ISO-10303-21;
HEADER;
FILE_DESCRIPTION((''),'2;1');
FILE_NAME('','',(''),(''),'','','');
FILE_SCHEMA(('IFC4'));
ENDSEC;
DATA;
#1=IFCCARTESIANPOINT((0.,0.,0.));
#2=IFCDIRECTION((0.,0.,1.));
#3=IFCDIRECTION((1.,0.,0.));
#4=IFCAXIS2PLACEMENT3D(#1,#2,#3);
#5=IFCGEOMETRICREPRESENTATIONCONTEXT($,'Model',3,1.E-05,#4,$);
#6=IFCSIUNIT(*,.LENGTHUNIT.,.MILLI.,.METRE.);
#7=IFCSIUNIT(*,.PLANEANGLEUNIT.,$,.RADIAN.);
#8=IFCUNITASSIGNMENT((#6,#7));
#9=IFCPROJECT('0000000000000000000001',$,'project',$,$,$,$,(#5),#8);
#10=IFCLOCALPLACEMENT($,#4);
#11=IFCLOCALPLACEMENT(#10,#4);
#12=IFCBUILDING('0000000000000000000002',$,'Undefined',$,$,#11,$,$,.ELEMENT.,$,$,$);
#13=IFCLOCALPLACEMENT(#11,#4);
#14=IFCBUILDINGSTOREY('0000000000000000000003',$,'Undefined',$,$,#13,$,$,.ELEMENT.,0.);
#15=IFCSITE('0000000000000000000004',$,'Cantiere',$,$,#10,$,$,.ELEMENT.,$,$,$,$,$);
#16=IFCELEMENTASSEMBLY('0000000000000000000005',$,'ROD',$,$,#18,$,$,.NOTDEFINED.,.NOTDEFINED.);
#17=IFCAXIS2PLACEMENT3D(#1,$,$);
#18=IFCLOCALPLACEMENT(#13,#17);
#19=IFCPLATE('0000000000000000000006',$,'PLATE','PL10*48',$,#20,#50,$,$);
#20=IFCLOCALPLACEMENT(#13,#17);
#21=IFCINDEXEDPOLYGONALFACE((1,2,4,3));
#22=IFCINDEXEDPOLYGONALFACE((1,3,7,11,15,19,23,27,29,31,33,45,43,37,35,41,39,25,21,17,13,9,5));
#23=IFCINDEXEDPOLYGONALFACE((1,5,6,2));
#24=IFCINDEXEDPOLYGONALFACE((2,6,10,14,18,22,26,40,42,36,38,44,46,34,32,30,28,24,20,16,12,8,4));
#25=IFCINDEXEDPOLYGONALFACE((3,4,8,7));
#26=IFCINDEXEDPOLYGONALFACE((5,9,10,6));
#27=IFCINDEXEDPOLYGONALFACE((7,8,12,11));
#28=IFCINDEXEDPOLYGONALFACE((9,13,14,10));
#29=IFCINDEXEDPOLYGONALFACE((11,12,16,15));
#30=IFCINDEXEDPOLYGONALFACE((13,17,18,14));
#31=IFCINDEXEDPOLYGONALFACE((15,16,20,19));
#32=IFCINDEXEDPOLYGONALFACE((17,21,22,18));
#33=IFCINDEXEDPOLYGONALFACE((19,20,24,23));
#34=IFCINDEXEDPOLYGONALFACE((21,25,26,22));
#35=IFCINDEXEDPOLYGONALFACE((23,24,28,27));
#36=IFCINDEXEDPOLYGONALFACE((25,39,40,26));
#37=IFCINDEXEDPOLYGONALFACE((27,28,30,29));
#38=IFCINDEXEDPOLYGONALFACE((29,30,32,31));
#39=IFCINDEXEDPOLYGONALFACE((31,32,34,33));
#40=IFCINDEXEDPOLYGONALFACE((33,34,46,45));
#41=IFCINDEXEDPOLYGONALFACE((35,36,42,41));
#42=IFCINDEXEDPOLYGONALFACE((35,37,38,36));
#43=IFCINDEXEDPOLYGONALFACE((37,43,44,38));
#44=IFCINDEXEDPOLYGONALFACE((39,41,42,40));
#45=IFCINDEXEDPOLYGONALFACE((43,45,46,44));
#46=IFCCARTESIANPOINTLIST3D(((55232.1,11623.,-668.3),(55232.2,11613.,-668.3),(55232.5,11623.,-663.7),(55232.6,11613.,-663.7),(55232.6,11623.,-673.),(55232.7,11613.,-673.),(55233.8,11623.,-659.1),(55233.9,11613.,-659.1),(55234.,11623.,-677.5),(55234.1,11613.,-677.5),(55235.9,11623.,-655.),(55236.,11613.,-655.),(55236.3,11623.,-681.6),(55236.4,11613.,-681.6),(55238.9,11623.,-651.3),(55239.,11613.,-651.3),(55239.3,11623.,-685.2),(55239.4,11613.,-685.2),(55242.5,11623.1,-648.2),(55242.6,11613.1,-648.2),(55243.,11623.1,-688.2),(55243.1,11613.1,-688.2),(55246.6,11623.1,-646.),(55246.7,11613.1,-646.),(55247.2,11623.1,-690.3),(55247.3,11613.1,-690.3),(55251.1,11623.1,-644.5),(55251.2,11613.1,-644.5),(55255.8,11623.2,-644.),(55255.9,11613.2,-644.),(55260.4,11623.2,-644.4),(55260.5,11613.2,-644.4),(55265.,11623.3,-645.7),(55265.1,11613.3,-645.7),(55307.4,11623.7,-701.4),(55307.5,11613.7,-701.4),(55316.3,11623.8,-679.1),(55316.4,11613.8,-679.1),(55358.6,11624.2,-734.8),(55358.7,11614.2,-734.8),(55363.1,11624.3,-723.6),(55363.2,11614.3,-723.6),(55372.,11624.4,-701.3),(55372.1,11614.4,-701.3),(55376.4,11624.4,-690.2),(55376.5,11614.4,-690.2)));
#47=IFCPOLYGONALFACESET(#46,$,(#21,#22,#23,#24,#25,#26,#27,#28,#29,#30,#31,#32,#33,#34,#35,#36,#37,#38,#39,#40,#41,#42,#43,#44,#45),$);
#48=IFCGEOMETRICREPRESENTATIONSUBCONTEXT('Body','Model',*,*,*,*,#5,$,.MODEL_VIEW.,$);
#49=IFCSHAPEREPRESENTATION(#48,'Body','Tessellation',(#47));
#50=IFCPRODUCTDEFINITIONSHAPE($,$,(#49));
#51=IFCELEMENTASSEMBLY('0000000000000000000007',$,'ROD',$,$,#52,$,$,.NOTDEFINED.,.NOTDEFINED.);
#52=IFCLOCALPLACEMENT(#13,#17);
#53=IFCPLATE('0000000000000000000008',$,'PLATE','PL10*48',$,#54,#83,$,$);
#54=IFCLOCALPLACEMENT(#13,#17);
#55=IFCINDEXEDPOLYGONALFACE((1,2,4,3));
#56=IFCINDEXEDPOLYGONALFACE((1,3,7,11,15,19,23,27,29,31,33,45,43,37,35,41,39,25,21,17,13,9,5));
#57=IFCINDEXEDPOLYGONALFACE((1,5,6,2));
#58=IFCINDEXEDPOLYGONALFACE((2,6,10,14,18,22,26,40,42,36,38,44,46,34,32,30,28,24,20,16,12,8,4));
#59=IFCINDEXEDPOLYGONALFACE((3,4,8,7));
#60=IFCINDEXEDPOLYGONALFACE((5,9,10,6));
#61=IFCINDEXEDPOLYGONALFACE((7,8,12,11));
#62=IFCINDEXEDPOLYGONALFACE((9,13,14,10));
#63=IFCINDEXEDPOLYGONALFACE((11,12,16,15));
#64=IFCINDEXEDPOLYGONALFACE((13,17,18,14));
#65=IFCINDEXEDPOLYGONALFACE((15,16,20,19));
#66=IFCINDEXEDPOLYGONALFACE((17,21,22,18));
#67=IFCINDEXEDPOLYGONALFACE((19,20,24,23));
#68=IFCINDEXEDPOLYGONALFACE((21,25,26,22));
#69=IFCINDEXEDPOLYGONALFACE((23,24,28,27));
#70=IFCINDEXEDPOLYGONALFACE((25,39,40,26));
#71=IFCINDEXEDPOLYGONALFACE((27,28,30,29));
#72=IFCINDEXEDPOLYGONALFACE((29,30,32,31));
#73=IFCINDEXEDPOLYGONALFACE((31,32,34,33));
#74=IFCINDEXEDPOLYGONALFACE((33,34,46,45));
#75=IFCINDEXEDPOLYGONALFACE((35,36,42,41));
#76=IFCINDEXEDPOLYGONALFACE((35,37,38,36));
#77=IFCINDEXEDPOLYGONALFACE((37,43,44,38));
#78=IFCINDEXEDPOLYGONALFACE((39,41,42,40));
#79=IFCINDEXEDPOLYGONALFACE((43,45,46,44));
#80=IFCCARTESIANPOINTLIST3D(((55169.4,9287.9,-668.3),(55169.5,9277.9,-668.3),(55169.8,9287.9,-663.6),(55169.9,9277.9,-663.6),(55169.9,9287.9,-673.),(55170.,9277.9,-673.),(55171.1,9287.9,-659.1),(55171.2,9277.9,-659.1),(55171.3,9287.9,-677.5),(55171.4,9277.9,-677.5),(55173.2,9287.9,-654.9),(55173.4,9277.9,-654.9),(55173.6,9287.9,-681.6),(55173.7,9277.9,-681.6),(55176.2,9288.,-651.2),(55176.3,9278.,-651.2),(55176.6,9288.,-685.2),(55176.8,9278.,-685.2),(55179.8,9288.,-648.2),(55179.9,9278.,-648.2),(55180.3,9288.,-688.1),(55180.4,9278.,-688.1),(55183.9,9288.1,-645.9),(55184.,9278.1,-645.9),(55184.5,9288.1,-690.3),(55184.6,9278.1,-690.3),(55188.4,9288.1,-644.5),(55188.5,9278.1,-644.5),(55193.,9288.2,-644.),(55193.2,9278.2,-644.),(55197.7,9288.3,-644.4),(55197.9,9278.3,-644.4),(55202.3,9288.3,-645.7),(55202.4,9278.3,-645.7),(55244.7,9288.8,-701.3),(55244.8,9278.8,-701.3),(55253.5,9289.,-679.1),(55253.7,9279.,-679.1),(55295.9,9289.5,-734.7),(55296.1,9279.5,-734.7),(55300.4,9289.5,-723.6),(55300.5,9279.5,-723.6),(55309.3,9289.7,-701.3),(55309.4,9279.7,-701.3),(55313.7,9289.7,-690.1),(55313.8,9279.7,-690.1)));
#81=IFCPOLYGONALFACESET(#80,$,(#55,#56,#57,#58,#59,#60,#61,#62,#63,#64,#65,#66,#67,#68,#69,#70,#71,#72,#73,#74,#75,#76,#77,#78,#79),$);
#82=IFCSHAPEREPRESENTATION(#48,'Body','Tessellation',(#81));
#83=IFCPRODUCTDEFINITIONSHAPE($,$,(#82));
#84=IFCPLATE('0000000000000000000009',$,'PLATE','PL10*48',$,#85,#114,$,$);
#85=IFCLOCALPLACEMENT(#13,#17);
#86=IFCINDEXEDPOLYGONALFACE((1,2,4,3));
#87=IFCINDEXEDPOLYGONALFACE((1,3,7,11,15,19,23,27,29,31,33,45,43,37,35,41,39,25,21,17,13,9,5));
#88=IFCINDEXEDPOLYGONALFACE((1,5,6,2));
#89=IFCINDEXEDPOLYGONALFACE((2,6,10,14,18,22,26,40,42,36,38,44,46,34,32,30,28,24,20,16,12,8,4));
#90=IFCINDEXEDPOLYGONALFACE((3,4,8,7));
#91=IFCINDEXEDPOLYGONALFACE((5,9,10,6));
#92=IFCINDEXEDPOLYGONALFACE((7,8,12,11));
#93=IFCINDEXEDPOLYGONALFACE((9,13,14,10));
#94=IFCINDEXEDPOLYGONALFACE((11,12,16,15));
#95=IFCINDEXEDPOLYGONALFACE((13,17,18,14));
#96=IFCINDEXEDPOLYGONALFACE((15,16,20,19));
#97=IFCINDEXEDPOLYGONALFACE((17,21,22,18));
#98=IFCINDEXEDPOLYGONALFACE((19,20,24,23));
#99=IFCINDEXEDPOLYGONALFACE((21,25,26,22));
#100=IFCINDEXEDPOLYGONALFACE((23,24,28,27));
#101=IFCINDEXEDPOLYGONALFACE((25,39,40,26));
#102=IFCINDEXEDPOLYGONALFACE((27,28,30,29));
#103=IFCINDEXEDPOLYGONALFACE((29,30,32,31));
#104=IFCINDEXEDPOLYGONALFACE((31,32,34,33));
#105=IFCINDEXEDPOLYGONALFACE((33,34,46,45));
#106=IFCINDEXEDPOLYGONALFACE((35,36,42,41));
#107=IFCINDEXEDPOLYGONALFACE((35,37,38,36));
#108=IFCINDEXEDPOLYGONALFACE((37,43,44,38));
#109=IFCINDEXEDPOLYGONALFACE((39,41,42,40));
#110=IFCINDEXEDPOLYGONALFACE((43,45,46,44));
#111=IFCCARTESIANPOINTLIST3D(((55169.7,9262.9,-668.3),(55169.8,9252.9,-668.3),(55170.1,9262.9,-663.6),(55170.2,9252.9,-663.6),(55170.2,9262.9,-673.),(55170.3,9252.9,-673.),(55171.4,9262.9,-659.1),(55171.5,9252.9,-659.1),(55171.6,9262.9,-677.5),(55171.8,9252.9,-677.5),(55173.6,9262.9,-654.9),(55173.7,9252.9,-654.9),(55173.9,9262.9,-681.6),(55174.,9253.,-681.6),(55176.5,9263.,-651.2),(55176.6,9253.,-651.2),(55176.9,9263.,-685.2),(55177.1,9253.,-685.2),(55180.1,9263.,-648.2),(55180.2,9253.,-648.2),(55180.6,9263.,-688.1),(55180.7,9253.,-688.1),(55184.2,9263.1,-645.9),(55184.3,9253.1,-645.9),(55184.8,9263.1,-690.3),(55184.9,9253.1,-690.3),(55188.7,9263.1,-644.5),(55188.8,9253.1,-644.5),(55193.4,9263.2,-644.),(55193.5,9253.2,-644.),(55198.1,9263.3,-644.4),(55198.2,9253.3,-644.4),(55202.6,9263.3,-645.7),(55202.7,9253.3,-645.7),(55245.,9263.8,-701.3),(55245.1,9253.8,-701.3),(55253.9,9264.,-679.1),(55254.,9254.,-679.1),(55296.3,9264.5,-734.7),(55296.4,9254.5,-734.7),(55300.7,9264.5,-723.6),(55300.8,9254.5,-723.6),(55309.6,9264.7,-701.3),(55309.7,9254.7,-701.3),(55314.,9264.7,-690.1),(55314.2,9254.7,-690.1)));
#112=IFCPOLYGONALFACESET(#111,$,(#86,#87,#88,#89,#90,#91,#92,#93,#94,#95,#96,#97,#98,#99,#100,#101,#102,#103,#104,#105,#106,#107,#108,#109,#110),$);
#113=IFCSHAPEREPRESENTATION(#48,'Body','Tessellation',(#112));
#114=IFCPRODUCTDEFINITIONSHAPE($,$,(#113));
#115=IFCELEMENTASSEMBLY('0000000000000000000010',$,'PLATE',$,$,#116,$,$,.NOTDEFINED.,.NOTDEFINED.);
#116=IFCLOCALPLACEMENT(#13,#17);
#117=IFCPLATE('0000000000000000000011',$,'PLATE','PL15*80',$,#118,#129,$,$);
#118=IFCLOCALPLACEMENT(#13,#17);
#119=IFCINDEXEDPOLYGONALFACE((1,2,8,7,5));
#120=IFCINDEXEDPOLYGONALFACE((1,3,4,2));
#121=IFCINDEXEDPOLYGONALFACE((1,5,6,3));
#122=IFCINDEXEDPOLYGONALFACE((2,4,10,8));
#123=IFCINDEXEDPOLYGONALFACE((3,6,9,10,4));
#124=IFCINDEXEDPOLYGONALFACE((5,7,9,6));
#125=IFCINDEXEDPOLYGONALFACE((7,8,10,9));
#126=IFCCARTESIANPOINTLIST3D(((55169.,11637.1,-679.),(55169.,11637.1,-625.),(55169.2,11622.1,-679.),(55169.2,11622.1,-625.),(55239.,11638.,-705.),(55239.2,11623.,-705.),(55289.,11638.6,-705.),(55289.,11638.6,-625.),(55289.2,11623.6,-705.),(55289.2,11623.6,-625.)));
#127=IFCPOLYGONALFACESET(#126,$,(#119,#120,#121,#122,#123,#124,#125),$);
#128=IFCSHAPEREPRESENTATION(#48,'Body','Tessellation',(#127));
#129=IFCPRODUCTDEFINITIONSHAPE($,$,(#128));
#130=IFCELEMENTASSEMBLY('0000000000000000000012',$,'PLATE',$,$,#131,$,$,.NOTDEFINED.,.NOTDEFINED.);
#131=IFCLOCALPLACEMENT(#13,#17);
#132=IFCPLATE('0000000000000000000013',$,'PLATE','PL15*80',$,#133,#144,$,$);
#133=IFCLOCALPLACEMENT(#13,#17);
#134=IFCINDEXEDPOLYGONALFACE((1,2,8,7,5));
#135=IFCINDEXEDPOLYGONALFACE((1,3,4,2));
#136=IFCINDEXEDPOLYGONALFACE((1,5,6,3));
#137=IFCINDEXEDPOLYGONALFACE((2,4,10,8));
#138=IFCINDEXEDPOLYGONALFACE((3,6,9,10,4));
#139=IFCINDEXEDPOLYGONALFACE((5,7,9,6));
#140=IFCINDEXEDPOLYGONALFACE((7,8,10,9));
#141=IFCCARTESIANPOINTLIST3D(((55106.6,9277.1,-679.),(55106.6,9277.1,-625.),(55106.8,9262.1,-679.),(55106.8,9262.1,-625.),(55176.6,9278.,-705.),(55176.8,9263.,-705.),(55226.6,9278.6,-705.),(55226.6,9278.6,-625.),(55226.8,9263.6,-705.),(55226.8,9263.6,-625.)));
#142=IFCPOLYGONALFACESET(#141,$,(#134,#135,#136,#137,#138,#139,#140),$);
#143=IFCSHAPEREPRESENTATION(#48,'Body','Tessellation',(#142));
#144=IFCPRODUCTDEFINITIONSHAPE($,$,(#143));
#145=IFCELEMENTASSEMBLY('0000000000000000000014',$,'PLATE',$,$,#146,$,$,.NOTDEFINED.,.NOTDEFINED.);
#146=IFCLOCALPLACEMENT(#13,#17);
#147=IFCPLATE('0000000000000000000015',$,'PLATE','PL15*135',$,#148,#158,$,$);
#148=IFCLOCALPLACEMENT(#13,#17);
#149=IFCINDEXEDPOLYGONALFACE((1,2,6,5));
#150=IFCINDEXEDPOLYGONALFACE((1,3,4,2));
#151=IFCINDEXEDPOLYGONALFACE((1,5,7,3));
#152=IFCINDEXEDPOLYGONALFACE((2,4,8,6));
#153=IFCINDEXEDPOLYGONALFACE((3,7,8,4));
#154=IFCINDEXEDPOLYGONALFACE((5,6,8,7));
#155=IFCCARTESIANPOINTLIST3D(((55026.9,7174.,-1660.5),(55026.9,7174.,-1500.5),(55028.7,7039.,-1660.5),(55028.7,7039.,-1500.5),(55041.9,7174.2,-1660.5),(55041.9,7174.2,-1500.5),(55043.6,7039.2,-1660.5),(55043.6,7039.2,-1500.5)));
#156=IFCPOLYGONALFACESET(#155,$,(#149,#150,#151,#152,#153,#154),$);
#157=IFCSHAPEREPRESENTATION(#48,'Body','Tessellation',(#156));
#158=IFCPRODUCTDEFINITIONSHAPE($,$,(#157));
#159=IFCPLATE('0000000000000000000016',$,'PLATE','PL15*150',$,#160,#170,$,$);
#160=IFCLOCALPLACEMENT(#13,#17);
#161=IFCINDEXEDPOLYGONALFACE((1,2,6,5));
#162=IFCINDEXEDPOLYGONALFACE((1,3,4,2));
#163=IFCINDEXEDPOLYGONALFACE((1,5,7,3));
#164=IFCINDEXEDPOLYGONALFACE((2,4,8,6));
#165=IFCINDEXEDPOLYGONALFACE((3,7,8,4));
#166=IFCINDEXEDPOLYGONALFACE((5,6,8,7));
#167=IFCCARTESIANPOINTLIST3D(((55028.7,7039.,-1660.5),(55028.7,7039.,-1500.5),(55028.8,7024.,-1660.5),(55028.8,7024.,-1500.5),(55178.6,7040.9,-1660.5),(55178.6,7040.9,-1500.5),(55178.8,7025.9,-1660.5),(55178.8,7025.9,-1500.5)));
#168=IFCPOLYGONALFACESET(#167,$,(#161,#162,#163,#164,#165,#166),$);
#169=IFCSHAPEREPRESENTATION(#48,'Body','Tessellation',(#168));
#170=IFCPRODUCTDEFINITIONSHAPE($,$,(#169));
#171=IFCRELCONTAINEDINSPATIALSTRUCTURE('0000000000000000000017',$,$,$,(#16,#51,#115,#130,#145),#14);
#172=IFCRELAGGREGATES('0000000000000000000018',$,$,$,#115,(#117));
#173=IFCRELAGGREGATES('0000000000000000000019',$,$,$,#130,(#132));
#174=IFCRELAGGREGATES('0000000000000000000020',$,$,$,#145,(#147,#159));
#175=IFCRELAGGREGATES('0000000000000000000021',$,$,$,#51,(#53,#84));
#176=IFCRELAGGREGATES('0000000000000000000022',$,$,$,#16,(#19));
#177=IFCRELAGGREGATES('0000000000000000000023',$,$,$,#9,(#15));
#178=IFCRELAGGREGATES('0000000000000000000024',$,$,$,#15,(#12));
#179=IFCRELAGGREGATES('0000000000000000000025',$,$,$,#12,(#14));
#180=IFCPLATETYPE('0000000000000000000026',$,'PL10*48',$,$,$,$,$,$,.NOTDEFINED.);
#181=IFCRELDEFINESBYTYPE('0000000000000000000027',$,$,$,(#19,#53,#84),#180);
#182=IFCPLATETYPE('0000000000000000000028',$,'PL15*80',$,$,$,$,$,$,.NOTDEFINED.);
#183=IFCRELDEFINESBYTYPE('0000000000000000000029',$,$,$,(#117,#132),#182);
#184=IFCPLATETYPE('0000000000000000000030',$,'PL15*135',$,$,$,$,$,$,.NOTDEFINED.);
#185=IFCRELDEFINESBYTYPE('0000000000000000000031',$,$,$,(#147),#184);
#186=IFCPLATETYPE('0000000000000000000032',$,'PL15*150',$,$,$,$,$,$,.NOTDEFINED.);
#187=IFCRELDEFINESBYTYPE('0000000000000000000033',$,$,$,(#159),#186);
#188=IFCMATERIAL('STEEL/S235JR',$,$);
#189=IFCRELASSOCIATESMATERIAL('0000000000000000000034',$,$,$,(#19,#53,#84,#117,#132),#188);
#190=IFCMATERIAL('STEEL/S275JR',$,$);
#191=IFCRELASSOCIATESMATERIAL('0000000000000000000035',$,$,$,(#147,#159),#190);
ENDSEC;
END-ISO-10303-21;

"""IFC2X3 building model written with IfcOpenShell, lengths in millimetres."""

from ifc_helpers import new_model, si_unit, frame, origin_with_axes, place, context, subcontext, project, spatial, polyline, outline, extrude, material, type_object, element, aggregate, save


model = new_model("IFC2X3")

# Units and contexts
model_context = context("Model", 3, precision=1e-05, world=origin_with_axes())
body_context = subcontext(model_context, "Body", "Model", "MODEL_VIEW")
ifc_project = project(units=[si_unit("LENGTHUNIT", "METRE", prefix="MILLI"), si_unit("PLANEANGLEUNIT", "RADIAN")], contexts=[model_context])

# Site, building, storey
site_placement = place(None, origin_with_axes())
site = spatial("IfcSite", under=ifc_project, at=site_placement, Name="Cantiere", CompositionType="ELEMENT")
building_placement = place(site_placement, origin_with_axes())
building = spatial("IfcBuilding", under=site, at=building_placement, Name="Undefined", CompositionType="ELEMENT")
storey_placement = place(building_placement, origin_with_axes())
storey = spatial("IfcBuildingStorey", under=building, at=storey_placement, Name="Undefined", CompositionType="ELEMENT", Elevation=0.0)

# Shared definitions
ifc_material_1 = material(Name="STEEL/S275JR")
ifc_material_2 = material(Name="STEEL/S235JR")

# Element assemblies, plates
plate_type_1 = type_object("IfcPlateType", Name="PL10*48", PredefinedType="NOTDEFINED")
assembly_1_placement = place(storey_placement, origin_with_axes())
assembly_1 = element("IfcElementAssembly", 1, at=assembly_1_placement, inside=storey, Name="ROD", AssemblyPlace="NOTDEFINED", PredefinedType="NOTDEFINED")
plate_1_placement = place(assembly_1_placement, frame((55376.5, 11619.4, -690.2), z_axis=(0.009999, -0.99995, 0.0), x_axis=(-0.928849, -0.009288, 0.370341)))
plate_1 = element("IfcPlate", 2, at=plate_1_placement, type_object=plate_type_1, material=ifc_material_2, Name="PLATE", Description="PL10*48", context=body_context, shape_type="SweptSolid", body=[
    extrude(outline(polyline([(0.0, 0.0), (120.0, 0.0), (124.7, 0.5), (129.2, 1.8), (133.3, 4.0), (137.0, 7.0), (140.0, 10.7), (142.2, 14.8), (143.5, 19.3), (144.0, 24.0), (144.0, 24.0), (143.5, 28.7), (142.2, 33.2), (140.0, 37.3), (137.0, 41.0), (133.3, 44.0), (129.2, 46.2), (124.7, 47.5), (120.0, 48.0), (0.0, 48.0), (0.0, 36.0), (60.0, 36.0), (60.0, 12.0), (0.0, 12.0), (0.0, 0.0)])), frame((0.0, 0.0, -5.0), z_axis=(0.0, 0.0, 1.0), x_axis=(1.0, 0.0, 0.0)), (0.0, 0.0, 1.0), 10.0),
])
assembly_2_placement = place(storey_placement, origin_with_axes())
assembly_2 = element("IfcElementAssembly", 3, at=assembly_2_placement, inside=storey, Name="ROD", AssemblyPlace="NOTDEFINED", PredefinedType="NOTDEFINED")
plate_2_placement = place(assembly_2_placement, frame((55313.8, 9284.7, -690.1), z_axis=(0.012617, -0.99992, 0.0), x_axis=(-0.928822, -0.01172, 0.370341)))
plate_2 = element("IfcPlate", 4, at=plate_2_placement, type_object=plate_type_1, material=ifc_material_2, Name="PLATE", Description="PL10*48", context=body_context, shape_type="SweptSolid", body=[
    extrude(outline(polyline([(0.0, 0.0), (120.0, 0.0), (124.7, 0.5), (129.2, 1.8), (133.3, 4.0), (137.0, 7.0), (140.0, 10.7), (142.2, 14.8), (143.5, 19.3), (144.0, 24.0), (144.0, 24.0), (143.5, 28.7), (142.2, 33.2), (140.0, 37.3), (137.0, 41.0), (133.3, 44.0), (129.2, 46.2), (124.7, 47.5), (120.0, 48.0), (0.0, 48.0), (0.0, 36.0), (60.0, 36.0), (60.0, 12.0), (0.0, 12.0), (0.0, 0.0)])), frame((0.0, 0.0, -5.0), z_axis=(0.0, 0.0, 1.0), x_axis=(1.0, 0.0, 0.0)), (0.0, 0.0, 1.0), 10.0),
])
plate_3_placement = place(assembly_2_placement, frame((55314.1, 9259.7, -690.1), z_axis=(0.012617, -0.99992, 0.0), x_axis=(-0.928822, -0.01172, 0.370341)))
plate_3 = element("IfcPlate", 5, at=plate_3_placement, type_object=plate_type_1, material=ifc_material_2, Name="PLATE", Description="PL10*48", context=body_context, shape_type="SweptSolid", body=[
    extrude(outline(polyline([(0.0, 0.0), (120.0, 0.0), (124.7, 0.5), (129.2, 1.8), (133.3, 4.0), (137.0, 7.0), (140.0, 10.7), (142.2, 14.8), (143.5, 19.3), (144.0, 24.0), (144.0, 24.0), (143.5, 28.7), (142.2, 33.2), (140.0, 37.3), (137.0, 41.0), (133.3, 44.0), (129.2, 46.2), (124.7, 47.5), (120.0, 48.0), (0.0, 48.0), (0.0, 36.0), (60.0, 36.0), (60.0, 12.0), (0.0, 12.0), (0.0, 0.0)])), frame((0.0, 0.0, -5.0), z_axis=(0.0, 0.0, 1.0), x_axis=(1.0, 0.0, 0.0)), (0.0, 0.0, 1.0), 10.0),
])

# Element assemblies, plates
assembly_3_placement = place(storey_placement, origin_with_axes())
assembly_3 = element("IfcElementAssembly", 6, at=assembly_3_placement, inside=storey, Name="PLATE", AssemblyPlace="NOTDEFINED", PredefinedType="NOTDEFINED")
plate_type_2 = type_object("IfcPlateType", Name="PL15*80", PredefinedType="NOTDEFINED")
plate_4_placement = place(assembly_3_placement, frame((55289.1, 11631.1, -625.0), z_axis=(0.012617, -0.99992, 0.0), x_axis=(-0.99992, -0.012617, 0.0)))
plate_4 = element("IfcPlate", 7, at=plate_4_placement, type_object=plate_type_2, material=ifc_material_2, Name="PLATE", Description="PL15*80", context=body_context, shape_type="SweptSolid", body=[
    extrude(outline(polyline([(0.0, 0.0), (120.0, 0.0), (120.0, 54.0), (50.0, 80.0), (0.0, 80.0), (0.0, 0.0)])), frame((0.0, 0.0, -7.5), z_axis=(0.0, 0.0, 1.0), x_axis=(1.0, 0.0, 0.0)), (0.0, 0.0, 1.0), 15.0),
])
aggregate(assembly_3, [plate_4])
assembly_4_placement = place(storey_placement, origin_with_axes())
assembly_4 = element("IfcElementAssembly", 8, at=assembly_4_placement, inside=storey, Name="PLATE", AssemblyPlace="NOTDEFINED", PredefinedType="NOTDEFINED")
plate_5_placement = place(assembly_4_placement, frame((55226.7, 9271.1, -625.0), z_axis=(0.012617, -0.99992, 0.0), x_axis=(-0.99992, -0.012617, 0.0)))
plate_5 = element("IfcPlate", 9, at=plate_5_placement, type_object=plate_type_2, material=ifc_material_2, Name="PLATE", Description="PL15*80", context=body_context, shape_type="SweptSolid", body=[
    extrude(outline(polyline([(0.0, 0.0), (120.0, 0.0), (120.0, 54.0), (50.0, 80.0), (0.0, 80.0), (0.0, 0.0)])), frame((0.0, 0.0, -7.5), z_axis=(0.0, 0.0, 1.0), x_axis=(1.0, 0.0, 0.0)), (0.0, 0.0, 1.0), 15.0),
])
aggregate(assembly_4, [plate_5])

# Element assembly, plates
assembly_5_placement = place(storey_placement, origin_with_axes())
assembly_5 = element("IfcElementAssembly", 10, at=assembly_5_placement, inside=storey, Name="PLATE", AssemblyPlace="NOTDEFINED", PredefinedType="NOTDEFINED")
plate_type_3 = type_object("IfcPlateType", Name="PL15*135", PredefinedType="NOTDEFINED")
plate_6_placement = place(assembly_5_placement, frame((55034.4, 7174.1, -1500.5), z_axis=(-0.99992, -0.012617, 0.0), x_axis=(0.0, 0.000001, -1.0)))
plate_6 = element("IfcPlate", 11, at=plate_6_placement, type_object=plate_type_3, material=ifc_material_1, Name="PLATE", Description="PL15*135", context=body_context, shape_type="SweptSolid", body=[
    extrude(outline(polyline([(0.0, 0.0), (160.0, 0.0), (160.0, 135.0), (0.0, 135.0), (0.0, 0.0)])), frame((0.0, 0.0, -7.5), z_axis=(0.0, 0.0, 1.0), x_axis=(1.0, 0.0, 0.0)), (0.0, 0.0, 1.0), 15.0),
])
plate_type_4 = type_object("IfcPlateType", Name="PL15*150", PredefinedType="NOTDEFINED")
plate_7_placement = place(assembly_5_placement, frame((55178.7, 7033.4, -1500.5), z_axis=(-0.012617, 0.99992, 0.0), x_axis=(0.0, 0.000001, -1.0)))
plate_7 = element("IfcPlate", 12, at=plate_7_placement, type_object=plate_type_4, material=ifc_material_1, Name="PLATE", Description="PL15*150", context=body_context, shape_type="SweptSolid", body=[
    extrude(outline(polyline([(0.0, 0.0), (160.0, 0.0), (160.0, 150.0), (0.0, 150.0), (0.0, 0.0)])), frame((0.0, 0.0, -7.5), z_axis=(0.0, 0.0, 1.0), x_axis=(1.0, 0.0, 0.0)), (0.0, 0.0, 1.0), 15.0),
])
aggregate(assembly_5, [plate_6, plate_7])

aggregate(assembly_2, [plate_2, plate_3])
aggregate(assembly_1, [plate_1])

save(model, "model.ifc")
